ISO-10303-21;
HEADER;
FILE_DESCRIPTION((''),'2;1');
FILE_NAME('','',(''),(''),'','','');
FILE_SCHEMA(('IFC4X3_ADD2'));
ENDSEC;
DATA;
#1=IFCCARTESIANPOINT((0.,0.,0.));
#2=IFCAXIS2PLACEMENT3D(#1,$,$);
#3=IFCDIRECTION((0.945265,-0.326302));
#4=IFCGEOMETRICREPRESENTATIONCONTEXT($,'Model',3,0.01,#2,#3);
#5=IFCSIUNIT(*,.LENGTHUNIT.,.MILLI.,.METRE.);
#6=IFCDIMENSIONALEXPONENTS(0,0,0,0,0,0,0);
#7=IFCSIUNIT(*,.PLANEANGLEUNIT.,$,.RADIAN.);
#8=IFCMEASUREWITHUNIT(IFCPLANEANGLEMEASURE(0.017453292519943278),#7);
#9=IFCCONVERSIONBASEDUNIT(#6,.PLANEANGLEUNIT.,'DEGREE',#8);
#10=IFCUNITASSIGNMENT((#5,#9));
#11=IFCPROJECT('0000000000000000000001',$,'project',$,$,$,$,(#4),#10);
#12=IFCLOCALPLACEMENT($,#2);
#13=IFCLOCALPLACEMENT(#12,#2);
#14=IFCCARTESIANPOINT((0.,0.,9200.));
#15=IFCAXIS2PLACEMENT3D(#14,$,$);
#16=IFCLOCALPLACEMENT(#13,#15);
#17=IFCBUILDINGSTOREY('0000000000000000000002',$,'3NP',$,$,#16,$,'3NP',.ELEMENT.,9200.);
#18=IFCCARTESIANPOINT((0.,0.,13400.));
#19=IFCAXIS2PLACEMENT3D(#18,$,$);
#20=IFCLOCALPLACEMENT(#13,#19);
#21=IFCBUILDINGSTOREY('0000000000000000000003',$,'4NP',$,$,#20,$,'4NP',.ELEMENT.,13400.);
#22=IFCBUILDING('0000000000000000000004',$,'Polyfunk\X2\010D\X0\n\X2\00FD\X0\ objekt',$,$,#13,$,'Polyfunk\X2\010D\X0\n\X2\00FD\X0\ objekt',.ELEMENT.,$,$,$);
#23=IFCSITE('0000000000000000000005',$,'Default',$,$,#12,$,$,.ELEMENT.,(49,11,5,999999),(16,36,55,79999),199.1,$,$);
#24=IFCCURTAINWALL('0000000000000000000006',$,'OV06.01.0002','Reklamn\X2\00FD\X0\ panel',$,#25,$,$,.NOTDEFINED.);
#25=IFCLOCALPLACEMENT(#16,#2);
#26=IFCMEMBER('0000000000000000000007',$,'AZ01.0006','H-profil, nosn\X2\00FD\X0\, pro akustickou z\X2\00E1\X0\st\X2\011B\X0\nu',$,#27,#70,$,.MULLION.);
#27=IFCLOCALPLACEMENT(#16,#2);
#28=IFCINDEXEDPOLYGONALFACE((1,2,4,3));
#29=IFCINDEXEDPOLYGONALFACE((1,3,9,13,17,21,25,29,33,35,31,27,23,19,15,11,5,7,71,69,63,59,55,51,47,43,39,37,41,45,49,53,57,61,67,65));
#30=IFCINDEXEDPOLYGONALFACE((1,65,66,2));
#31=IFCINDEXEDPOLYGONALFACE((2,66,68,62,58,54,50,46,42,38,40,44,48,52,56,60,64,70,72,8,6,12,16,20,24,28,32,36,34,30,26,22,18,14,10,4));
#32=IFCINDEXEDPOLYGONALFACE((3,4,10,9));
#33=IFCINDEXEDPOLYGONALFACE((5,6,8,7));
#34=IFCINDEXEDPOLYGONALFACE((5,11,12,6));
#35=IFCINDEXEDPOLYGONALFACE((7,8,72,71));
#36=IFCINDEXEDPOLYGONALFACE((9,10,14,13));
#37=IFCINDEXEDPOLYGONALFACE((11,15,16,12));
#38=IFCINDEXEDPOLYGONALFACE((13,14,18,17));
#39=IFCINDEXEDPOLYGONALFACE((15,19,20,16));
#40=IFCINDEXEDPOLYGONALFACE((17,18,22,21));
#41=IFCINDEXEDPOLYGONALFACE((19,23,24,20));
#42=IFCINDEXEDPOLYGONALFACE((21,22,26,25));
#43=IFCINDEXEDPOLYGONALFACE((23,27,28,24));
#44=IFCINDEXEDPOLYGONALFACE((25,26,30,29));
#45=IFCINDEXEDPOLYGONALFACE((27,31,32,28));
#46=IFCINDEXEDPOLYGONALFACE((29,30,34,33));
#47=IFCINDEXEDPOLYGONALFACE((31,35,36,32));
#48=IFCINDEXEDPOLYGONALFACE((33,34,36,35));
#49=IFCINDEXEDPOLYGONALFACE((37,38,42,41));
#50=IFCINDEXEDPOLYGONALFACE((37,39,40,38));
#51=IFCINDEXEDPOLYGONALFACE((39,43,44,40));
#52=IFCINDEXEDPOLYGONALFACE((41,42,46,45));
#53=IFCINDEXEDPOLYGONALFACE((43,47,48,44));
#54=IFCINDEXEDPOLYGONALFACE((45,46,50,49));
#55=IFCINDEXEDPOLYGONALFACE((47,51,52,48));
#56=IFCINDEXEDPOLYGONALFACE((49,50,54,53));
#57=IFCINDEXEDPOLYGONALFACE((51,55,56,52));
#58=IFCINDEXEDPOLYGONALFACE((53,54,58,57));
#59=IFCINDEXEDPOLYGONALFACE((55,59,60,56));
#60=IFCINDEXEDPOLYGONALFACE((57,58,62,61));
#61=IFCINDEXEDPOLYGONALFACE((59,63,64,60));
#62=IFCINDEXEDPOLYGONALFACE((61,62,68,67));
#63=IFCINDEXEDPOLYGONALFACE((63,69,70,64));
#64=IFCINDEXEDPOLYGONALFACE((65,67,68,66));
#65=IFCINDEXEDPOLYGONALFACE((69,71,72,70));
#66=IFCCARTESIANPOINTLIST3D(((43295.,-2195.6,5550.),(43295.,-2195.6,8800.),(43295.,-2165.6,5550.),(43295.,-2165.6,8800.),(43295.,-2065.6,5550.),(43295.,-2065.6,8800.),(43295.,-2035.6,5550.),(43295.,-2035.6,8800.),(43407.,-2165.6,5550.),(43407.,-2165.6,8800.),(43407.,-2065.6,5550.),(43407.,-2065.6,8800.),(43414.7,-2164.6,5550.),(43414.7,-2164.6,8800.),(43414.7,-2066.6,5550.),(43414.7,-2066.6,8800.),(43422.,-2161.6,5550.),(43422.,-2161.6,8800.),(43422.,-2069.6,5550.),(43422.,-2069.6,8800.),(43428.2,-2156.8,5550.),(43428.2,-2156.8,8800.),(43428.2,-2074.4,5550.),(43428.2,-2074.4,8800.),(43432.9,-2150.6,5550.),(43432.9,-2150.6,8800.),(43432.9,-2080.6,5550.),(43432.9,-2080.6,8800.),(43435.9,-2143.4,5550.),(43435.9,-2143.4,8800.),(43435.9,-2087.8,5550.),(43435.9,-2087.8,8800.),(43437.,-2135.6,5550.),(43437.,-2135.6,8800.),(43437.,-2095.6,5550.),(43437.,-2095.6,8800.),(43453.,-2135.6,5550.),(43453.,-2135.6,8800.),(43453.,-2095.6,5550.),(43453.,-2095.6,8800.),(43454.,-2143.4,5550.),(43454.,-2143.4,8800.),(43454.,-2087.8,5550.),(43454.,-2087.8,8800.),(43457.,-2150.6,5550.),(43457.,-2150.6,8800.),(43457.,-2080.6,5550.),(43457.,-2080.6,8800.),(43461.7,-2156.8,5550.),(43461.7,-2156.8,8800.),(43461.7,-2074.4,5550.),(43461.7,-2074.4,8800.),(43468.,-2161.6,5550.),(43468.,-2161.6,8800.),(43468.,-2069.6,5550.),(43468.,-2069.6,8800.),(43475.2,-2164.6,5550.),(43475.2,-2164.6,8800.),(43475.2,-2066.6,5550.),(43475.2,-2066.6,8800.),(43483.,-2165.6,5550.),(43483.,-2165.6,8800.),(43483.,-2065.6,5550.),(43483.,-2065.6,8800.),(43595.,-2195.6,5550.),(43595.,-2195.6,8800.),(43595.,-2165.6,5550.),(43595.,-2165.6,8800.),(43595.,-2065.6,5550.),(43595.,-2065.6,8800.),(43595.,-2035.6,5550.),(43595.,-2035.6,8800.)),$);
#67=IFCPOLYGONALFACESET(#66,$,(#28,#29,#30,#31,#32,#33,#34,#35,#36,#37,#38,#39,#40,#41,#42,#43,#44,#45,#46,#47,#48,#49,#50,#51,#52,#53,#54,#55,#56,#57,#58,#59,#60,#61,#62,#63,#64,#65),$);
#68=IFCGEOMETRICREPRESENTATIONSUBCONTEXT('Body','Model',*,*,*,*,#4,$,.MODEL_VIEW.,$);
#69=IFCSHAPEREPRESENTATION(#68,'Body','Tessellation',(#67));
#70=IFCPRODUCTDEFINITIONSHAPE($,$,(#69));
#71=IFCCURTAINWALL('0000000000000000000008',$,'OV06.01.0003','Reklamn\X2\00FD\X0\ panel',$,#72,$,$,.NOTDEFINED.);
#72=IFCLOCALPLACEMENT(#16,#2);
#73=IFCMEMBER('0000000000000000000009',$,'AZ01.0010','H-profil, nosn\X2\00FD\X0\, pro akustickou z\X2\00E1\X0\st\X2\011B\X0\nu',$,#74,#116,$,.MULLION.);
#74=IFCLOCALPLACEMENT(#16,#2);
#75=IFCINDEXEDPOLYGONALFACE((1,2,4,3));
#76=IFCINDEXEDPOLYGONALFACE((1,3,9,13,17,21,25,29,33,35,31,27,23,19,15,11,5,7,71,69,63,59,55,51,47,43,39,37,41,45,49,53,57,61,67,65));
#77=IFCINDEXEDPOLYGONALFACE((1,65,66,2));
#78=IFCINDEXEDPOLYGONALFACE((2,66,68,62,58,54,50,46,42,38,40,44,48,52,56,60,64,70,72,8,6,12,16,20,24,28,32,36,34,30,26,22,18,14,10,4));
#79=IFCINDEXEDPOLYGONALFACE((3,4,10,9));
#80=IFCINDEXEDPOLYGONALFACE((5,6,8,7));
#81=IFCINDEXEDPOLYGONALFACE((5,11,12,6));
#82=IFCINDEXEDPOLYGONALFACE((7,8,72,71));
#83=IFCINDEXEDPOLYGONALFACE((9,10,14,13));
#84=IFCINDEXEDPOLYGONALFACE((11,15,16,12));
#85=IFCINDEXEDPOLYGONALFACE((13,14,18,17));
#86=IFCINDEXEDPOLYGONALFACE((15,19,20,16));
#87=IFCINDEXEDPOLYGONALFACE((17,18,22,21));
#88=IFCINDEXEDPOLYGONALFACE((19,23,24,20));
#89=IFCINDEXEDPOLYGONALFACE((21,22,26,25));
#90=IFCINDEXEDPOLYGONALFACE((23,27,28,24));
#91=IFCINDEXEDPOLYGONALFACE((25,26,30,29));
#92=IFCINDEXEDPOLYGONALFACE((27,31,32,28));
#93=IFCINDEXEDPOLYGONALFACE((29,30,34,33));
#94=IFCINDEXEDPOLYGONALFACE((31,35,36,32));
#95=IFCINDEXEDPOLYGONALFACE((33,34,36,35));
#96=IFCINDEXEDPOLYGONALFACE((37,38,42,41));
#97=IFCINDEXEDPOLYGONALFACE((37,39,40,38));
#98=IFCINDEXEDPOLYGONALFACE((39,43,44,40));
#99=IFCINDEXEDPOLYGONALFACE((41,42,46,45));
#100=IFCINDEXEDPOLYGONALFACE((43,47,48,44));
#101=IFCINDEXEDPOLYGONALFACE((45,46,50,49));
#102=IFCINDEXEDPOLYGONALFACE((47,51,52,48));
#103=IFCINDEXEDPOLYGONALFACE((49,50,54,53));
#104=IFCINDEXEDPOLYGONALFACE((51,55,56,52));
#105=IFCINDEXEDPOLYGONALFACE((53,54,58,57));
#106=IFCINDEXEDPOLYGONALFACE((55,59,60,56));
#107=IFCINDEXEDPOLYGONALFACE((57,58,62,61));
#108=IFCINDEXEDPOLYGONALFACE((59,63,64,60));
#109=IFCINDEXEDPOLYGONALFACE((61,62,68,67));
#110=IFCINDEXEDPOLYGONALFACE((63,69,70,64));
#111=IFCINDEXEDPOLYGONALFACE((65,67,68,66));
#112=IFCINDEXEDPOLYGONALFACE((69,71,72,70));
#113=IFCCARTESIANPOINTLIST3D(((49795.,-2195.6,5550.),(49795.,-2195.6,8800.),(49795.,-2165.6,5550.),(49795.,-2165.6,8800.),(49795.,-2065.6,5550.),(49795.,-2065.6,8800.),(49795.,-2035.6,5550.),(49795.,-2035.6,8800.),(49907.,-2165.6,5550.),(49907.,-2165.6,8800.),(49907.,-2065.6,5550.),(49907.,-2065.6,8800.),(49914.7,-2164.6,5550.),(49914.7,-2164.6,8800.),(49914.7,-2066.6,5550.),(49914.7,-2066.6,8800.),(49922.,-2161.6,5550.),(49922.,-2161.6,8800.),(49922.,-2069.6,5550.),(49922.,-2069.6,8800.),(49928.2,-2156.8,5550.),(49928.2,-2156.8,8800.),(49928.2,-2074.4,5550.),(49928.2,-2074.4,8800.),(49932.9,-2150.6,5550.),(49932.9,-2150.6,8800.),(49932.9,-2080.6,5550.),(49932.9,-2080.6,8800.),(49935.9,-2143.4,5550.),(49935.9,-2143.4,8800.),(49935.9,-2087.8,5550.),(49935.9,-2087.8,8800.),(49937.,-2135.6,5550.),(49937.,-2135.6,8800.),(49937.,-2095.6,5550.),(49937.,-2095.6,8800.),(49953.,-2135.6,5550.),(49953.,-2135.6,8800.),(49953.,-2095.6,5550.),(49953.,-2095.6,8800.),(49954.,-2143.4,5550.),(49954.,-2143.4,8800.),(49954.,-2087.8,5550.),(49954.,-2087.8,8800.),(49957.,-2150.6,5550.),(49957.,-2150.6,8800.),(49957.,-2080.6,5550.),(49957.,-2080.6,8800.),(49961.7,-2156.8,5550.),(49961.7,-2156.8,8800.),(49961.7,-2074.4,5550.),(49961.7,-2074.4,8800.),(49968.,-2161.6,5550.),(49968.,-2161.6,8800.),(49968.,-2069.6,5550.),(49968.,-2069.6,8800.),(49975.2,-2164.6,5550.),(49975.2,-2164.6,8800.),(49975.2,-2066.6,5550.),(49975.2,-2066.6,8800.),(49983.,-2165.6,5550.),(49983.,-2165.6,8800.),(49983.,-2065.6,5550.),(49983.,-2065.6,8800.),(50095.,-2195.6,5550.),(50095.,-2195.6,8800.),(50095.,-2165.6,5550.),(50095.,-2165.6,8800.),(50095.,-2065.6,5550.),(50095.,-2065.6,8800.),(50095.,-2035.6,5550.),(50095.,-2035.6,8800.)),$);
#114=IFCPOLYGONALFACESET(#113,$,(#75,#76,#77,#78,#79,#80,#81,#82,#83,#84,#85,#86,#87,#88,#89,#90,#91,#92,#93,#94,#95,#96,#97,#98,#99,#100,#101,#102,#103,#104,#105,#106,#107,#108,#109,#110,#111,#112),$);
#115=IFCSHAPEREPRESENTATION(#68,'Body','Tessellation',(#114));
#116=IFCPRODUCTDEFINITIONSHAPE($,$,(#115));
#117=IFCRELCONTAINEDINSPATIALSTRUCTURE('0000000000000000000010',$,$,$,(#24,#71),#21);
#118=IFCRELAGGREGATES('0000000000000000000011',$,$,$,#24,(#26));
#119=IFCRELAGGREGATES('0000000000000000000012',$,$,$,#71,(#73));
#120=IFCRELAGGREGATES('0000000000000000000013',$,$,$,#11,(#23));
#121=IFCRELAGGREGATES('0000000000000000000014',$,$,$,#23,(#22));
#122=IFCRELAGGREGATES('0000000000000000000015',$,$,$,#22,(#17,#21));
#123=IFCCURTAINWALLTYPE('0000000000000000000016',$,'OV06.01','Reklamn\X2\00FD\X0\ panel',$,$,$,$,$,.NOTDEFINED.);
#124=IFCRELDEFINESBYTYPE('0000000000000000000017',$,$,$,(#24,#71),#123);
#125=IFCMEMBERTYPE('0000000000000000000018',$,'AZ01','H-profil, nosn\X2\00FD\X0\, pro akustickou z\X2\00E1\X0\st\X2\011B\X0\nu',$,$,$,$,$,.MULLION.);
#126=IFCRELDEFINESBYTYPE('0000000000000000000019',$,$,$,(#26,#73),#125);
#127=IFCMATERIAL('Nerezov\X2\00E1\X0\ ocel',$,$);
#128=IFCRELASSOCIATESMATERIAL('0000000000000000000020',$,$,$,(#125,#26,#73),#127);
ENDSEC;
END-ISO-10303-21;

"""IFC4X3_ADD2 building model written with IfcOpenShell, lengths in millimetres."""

from ifc_helpers import new_model, entity, si_unit, converted_unit, direction, frame, frame_2d, origin, place, context, subcontext, project, spatial, polyline, circle_curve, parameter, trimmed, segment, composite_curve, outline, extrude, source, transform, mapped, material, material_profile, profile_set, profile_usage, type_object, element, aggregate, save


model = new_model("IFC4X3_ADD2")

# Units and contexts
model_context = context("Model", 3, precision=0.01, world=origin(), true_north=direction((0.945265, -0.326302)))
body_context = subcontext(model_context, "Body", "Model", "MODEL_VIEW")
ifc_project = project(units=[si_unit("LENGTHUNIT", "METRE", prefix="MILLI"), converted_unit("PLANEANGLEUNIT", "DEGREE", entity("IfcPlaneAngleMeasure", 0.017453292519943278), si_unit("PLANEANGLEUNIT", "RADIAN"), dimensions=[0, 0, 0, 0, 0, 0, 0])], contexts=[model_context])

# Site, building, storey
site_placement = place(None, origin())
site = spatial("IfcSite", under=ifc_project, at=site_placement, Name="Default", CompositionType="ELEMENT", RefLatitude=(49, 11, 5, 999999), RefLongitude=(16, 36, 55, 79999), RefElevation=199.1)
building_placement = place(site_placement, origin())
building = spatial("IfcBuilding", under=site, at=building_placement, Name="Polyfunkčný objekt", LongName="Polyfunkčný objekt", CompositionType="ELEMENT")
storey_1_placement = place(building_placement, frame((0.0, 0.0, 9200.0)))
storey_1 = spatial("IfcBuildingStorey", under=building, at=storey_1_placement, Name="3NP", LongName="3NP", CompositionType="ELEMENT", Elevation=9200.0)

# Shared definitions
storey_2_placement = place(building_placement, frame((0.0, 0.0, 13400.0)))
storey_2 = spatial("IfcBuildingStorey", under=building, at=storey_2_placement, Name="4NP", LongName="4NP", CompositionType="ELEMENT", Elevation=13400.0)

# Shared definitions
ifc_material_1 = material(Name="Nerezová ocel")
ifc_material_profile_1 = material_profile(ifc_material_1, outline(composite_curve([segment(polyline([(50.0, -150.0), (80.0, -150.0)]), True, "CONTINUOUS"), segment(polyline([(80.0, -150.0), (80.0, 150.0)]), True, "CONTINUOUS"), segment(polyline([(80.0, 150.0), (50.0, 150.0)]), True, "CONTINUOUS"), segment(polyline([(50.0, 150.0), (50.0, 38.0)]), True, "CONTINUOUS"), segment(trimmed(circle_curve(frame_2d((20.0, 38.0), x_axis=(0.0, 1.0)), 30.0), [parameter(180.0)], [parameter(270.0)], True, "PARAMETER"), False, "CONTINUOUS"), segment(polyline([(20.0, 8.0), (-20.0, 8.0)]), True, "CONTINUOUS"), segment(trimmed(circle_curve(frame_2d((-20.0, 38.0), x_axis=(0.0, 1.0)), 30.0), [parameter(90.0)], [parameter(180.0)], True, "PARAMETER"), False, "CONTINUOUS"), segment(polyline([(-50.0, 38.0), (-50.0, 150.0)]), True, "CONTINUOUS"), segment(polyline([(-50.0, 150.0), (-80.0, 150.0)]), True, "CONTINUOUS"), segment(polyline([(-80.0, 150.0), (-80.0, -150.0)]), True, "CONTINUOUS"), segment(polyline([(-80.0, -150.0), (-50.0, -150.0)]), True, "CONTINUOUS"), segment(polyline([(-50.0, -150.0), (-50.0, -38.0)]), True, "CONTINUOUS"), segment(trimmed(circle_curve(frame_2d((-20.0, -38.0), x_axis=(0.0, 1.0)), 30.0), [parameter(0.0)], [parameter(90.0)], True, "PARAMETER"), False, "CONTINUOUS"), segment(polyline([(-20.0, -8.0), (20.0, -8.0)]), True, "CONTINUOUS"), segment(trimmed(circle_curve(frame_2d((20.0, -38.0), x_axis=(0.0, 1.0)), 30.0), [parameter(270.0)], [parameter(0.0)], True, "PARAMETER"), False, "CONTINUOUS"), segment(polyline([(50.0, -38.0), (50.0, -150.0)]), True, "CONTINUOUS")], self_intersect=False)), Name="Profil zástena")
ifc_profile_set_1 = profile_set([ifc_material_profile_1], Name="Profil zástena")
ifc_profile_usage_1 = profile_usage(ifc_profile_set_1)
member_type_1 = type_object("IfcMemberType", Name="AZ01", Description="H-profil, nosný, pro akustickou zástěnu", PredefinedType="MULLION", material=ifc_profile_set_1)

# Curtain walls, members
curtain_wall_type_1 = type_object("IfcCurtainWallType", Name="OV06.01", Description="Reklamný panel", PredefinedType="NOTDEFINED")
curtain_wall_1_placement = place(storey_2_placement, frame((0.0, 0.0, -13400.0)))
curtain_wall_1 = element("IfcCurtainWall", 1, at=curtain_wall_1_placement, inside=storey_2, type_object=curtain_wall_type_1, Name="OV06.01.0002", Description="Reklamný panel", PredefinedType="NOTDEFINED")
shared_shape_1 = source(origin(), body_context, "Body", "SweptSolid", [
    extrude(outline(composite_curve([segment(polyline([(50.0, -150.0), (80.0, -150.0)]), True, "CONTINUOUS"), segment(polyline([(80.0, -150.0), (80.0, 150.0)]), True, "CONTINUOUS"), segment(polyline([(80.0, 150.0), (50.0, 150.0)]), True, "CONTINUOUS"), segment(polyline([(50.0, 150.0), (50.0, 38.0)]), True, "CONTINUOUS"), segment(trimmed(circle_curve(frame_2d((20.0, 38.0), x_axis=(0.0, 1.0)), 30.0), [parameter(180.0)], [parameter(270.0)], True, "PARAMETER"), False, "CONTINUOUS"), segment(polyline([(20.0, 8.0), (-20.0, 8.0)]), True, "CONTINUOUS"), segment(trimmed(circle_curve(frame_2d((-20.0, 38.0), x_axis=(0.0, 1.0)), 30.0), [parameter(90.0)], [parameter(180.0)], True, "PARAMETER"), False, "CONTINUOUS"), segment(polyline([(-50.0, 38.0), (-50.0, 150.0)]), True, "CONTINUOUS"), segment(polyline([(-50.0, 150.0), (-80.0, 150.0)]), True, "CONTINUOUS"), segment(polyline([(-80.0, 150.0), (-80.0, -150.0)]), True, "CONTINUOUS"), segment(polyline([(-80.0, -150.0), (-50.0, -150.0)]), True, "CONTINUOUS"), segment(polyline([(-50.0, -150.0), (-50.0, -38.0)]), True, "CONTINUOUS"), segment(trimmed(circle_curve(frame_2d((-20.0, -38.0), x_axis=(0.0, 1.0)), 30.0), [parameter(0.0)], [parameter(90.0)], True, "PARAMETER"), False, "CONTINUOUS"), segment(polyline([(-20.0, -8.0), (20.0, -8.0)]), True, "CONTINUOUS"), segment(trimmed(circle_curve(frame_2d((20.0, -38.0), x_axis=(0.0, 1.0)), 30.0), [parameter(270.0)], [parameter(0.0)], True, "PARAMETER"), False, "CONTINUOUS"), segment(polyline([(50.0, -38.0), (50.0, -150.0)]), True, "CONTINUOUS")], self_intersect=False)), frame((-150.0, 0.0, -3250.0), z_axis=(0.0, 0.0, 1.0), x_axis=(0.0, 1.0, 0.0)), (0.0, 0.0, 1.0), 3250.0),
])
member_1_placement = place(curtain_wall_1_placement, frame((43295.0, -2115.6, 18000.0), z_axis=(0.0, 0.0, 1.0), x_axis=(-1.0, 0.0, 0.0)))
member_1 = element("IfcMember", 2, at=member_1_placement, type_object=member_type_1, material=ifc_profile_usage_1, Name="AZ01.0006", Description="H-profil, nosný, pro akustickou zástěnu", PredefinedType="MULLION", context=body_context, shape_type="MappedRepresentation", body=[
    mapped(shared_shape_1, transform((0.0, 0.0, 0.0), scale=1.0)),
])
curtain_wall_2_placement = place(storey_2_placement, frame((0.0, 0.0, -13400.0)))
curtain_wall_2 = element("IfcCurtainWall", 3, at=curtain_wall_2_placement, inside=storey_2, type_object=curtain_wall_type_1, Name="OV06.01.0003", Description="Reklamný panel", PredefinedType="NOTDEFINED")
member_2_placement = place(curtain_wall_2_placement, frame((49795.0, -2115.6, 18000.0), z_axis=(0.0, 0.0, 1.0), x_axis=(-1.0, 0.0, 0.0)))
member_2 = element("IfcMember", 4, at=member_2_placement, type_object=member_type_1, material=ifc_profile_usage_1, Name="AZ01.0010", Description="H-profil, nosný, pro akustickou zástěnu", PredefinedType="MULLION", context=body_context, shape_type="MappedRepresentation", body=[
    mapped(shared_shape_1, transform((0.0, 0.0, 0.0), scale=1.0)),
])

aggregate(curtain_wall_1, [member_1])
aggregate(curtain_wall_2, [member_2])

save(model, "model.ifc")
